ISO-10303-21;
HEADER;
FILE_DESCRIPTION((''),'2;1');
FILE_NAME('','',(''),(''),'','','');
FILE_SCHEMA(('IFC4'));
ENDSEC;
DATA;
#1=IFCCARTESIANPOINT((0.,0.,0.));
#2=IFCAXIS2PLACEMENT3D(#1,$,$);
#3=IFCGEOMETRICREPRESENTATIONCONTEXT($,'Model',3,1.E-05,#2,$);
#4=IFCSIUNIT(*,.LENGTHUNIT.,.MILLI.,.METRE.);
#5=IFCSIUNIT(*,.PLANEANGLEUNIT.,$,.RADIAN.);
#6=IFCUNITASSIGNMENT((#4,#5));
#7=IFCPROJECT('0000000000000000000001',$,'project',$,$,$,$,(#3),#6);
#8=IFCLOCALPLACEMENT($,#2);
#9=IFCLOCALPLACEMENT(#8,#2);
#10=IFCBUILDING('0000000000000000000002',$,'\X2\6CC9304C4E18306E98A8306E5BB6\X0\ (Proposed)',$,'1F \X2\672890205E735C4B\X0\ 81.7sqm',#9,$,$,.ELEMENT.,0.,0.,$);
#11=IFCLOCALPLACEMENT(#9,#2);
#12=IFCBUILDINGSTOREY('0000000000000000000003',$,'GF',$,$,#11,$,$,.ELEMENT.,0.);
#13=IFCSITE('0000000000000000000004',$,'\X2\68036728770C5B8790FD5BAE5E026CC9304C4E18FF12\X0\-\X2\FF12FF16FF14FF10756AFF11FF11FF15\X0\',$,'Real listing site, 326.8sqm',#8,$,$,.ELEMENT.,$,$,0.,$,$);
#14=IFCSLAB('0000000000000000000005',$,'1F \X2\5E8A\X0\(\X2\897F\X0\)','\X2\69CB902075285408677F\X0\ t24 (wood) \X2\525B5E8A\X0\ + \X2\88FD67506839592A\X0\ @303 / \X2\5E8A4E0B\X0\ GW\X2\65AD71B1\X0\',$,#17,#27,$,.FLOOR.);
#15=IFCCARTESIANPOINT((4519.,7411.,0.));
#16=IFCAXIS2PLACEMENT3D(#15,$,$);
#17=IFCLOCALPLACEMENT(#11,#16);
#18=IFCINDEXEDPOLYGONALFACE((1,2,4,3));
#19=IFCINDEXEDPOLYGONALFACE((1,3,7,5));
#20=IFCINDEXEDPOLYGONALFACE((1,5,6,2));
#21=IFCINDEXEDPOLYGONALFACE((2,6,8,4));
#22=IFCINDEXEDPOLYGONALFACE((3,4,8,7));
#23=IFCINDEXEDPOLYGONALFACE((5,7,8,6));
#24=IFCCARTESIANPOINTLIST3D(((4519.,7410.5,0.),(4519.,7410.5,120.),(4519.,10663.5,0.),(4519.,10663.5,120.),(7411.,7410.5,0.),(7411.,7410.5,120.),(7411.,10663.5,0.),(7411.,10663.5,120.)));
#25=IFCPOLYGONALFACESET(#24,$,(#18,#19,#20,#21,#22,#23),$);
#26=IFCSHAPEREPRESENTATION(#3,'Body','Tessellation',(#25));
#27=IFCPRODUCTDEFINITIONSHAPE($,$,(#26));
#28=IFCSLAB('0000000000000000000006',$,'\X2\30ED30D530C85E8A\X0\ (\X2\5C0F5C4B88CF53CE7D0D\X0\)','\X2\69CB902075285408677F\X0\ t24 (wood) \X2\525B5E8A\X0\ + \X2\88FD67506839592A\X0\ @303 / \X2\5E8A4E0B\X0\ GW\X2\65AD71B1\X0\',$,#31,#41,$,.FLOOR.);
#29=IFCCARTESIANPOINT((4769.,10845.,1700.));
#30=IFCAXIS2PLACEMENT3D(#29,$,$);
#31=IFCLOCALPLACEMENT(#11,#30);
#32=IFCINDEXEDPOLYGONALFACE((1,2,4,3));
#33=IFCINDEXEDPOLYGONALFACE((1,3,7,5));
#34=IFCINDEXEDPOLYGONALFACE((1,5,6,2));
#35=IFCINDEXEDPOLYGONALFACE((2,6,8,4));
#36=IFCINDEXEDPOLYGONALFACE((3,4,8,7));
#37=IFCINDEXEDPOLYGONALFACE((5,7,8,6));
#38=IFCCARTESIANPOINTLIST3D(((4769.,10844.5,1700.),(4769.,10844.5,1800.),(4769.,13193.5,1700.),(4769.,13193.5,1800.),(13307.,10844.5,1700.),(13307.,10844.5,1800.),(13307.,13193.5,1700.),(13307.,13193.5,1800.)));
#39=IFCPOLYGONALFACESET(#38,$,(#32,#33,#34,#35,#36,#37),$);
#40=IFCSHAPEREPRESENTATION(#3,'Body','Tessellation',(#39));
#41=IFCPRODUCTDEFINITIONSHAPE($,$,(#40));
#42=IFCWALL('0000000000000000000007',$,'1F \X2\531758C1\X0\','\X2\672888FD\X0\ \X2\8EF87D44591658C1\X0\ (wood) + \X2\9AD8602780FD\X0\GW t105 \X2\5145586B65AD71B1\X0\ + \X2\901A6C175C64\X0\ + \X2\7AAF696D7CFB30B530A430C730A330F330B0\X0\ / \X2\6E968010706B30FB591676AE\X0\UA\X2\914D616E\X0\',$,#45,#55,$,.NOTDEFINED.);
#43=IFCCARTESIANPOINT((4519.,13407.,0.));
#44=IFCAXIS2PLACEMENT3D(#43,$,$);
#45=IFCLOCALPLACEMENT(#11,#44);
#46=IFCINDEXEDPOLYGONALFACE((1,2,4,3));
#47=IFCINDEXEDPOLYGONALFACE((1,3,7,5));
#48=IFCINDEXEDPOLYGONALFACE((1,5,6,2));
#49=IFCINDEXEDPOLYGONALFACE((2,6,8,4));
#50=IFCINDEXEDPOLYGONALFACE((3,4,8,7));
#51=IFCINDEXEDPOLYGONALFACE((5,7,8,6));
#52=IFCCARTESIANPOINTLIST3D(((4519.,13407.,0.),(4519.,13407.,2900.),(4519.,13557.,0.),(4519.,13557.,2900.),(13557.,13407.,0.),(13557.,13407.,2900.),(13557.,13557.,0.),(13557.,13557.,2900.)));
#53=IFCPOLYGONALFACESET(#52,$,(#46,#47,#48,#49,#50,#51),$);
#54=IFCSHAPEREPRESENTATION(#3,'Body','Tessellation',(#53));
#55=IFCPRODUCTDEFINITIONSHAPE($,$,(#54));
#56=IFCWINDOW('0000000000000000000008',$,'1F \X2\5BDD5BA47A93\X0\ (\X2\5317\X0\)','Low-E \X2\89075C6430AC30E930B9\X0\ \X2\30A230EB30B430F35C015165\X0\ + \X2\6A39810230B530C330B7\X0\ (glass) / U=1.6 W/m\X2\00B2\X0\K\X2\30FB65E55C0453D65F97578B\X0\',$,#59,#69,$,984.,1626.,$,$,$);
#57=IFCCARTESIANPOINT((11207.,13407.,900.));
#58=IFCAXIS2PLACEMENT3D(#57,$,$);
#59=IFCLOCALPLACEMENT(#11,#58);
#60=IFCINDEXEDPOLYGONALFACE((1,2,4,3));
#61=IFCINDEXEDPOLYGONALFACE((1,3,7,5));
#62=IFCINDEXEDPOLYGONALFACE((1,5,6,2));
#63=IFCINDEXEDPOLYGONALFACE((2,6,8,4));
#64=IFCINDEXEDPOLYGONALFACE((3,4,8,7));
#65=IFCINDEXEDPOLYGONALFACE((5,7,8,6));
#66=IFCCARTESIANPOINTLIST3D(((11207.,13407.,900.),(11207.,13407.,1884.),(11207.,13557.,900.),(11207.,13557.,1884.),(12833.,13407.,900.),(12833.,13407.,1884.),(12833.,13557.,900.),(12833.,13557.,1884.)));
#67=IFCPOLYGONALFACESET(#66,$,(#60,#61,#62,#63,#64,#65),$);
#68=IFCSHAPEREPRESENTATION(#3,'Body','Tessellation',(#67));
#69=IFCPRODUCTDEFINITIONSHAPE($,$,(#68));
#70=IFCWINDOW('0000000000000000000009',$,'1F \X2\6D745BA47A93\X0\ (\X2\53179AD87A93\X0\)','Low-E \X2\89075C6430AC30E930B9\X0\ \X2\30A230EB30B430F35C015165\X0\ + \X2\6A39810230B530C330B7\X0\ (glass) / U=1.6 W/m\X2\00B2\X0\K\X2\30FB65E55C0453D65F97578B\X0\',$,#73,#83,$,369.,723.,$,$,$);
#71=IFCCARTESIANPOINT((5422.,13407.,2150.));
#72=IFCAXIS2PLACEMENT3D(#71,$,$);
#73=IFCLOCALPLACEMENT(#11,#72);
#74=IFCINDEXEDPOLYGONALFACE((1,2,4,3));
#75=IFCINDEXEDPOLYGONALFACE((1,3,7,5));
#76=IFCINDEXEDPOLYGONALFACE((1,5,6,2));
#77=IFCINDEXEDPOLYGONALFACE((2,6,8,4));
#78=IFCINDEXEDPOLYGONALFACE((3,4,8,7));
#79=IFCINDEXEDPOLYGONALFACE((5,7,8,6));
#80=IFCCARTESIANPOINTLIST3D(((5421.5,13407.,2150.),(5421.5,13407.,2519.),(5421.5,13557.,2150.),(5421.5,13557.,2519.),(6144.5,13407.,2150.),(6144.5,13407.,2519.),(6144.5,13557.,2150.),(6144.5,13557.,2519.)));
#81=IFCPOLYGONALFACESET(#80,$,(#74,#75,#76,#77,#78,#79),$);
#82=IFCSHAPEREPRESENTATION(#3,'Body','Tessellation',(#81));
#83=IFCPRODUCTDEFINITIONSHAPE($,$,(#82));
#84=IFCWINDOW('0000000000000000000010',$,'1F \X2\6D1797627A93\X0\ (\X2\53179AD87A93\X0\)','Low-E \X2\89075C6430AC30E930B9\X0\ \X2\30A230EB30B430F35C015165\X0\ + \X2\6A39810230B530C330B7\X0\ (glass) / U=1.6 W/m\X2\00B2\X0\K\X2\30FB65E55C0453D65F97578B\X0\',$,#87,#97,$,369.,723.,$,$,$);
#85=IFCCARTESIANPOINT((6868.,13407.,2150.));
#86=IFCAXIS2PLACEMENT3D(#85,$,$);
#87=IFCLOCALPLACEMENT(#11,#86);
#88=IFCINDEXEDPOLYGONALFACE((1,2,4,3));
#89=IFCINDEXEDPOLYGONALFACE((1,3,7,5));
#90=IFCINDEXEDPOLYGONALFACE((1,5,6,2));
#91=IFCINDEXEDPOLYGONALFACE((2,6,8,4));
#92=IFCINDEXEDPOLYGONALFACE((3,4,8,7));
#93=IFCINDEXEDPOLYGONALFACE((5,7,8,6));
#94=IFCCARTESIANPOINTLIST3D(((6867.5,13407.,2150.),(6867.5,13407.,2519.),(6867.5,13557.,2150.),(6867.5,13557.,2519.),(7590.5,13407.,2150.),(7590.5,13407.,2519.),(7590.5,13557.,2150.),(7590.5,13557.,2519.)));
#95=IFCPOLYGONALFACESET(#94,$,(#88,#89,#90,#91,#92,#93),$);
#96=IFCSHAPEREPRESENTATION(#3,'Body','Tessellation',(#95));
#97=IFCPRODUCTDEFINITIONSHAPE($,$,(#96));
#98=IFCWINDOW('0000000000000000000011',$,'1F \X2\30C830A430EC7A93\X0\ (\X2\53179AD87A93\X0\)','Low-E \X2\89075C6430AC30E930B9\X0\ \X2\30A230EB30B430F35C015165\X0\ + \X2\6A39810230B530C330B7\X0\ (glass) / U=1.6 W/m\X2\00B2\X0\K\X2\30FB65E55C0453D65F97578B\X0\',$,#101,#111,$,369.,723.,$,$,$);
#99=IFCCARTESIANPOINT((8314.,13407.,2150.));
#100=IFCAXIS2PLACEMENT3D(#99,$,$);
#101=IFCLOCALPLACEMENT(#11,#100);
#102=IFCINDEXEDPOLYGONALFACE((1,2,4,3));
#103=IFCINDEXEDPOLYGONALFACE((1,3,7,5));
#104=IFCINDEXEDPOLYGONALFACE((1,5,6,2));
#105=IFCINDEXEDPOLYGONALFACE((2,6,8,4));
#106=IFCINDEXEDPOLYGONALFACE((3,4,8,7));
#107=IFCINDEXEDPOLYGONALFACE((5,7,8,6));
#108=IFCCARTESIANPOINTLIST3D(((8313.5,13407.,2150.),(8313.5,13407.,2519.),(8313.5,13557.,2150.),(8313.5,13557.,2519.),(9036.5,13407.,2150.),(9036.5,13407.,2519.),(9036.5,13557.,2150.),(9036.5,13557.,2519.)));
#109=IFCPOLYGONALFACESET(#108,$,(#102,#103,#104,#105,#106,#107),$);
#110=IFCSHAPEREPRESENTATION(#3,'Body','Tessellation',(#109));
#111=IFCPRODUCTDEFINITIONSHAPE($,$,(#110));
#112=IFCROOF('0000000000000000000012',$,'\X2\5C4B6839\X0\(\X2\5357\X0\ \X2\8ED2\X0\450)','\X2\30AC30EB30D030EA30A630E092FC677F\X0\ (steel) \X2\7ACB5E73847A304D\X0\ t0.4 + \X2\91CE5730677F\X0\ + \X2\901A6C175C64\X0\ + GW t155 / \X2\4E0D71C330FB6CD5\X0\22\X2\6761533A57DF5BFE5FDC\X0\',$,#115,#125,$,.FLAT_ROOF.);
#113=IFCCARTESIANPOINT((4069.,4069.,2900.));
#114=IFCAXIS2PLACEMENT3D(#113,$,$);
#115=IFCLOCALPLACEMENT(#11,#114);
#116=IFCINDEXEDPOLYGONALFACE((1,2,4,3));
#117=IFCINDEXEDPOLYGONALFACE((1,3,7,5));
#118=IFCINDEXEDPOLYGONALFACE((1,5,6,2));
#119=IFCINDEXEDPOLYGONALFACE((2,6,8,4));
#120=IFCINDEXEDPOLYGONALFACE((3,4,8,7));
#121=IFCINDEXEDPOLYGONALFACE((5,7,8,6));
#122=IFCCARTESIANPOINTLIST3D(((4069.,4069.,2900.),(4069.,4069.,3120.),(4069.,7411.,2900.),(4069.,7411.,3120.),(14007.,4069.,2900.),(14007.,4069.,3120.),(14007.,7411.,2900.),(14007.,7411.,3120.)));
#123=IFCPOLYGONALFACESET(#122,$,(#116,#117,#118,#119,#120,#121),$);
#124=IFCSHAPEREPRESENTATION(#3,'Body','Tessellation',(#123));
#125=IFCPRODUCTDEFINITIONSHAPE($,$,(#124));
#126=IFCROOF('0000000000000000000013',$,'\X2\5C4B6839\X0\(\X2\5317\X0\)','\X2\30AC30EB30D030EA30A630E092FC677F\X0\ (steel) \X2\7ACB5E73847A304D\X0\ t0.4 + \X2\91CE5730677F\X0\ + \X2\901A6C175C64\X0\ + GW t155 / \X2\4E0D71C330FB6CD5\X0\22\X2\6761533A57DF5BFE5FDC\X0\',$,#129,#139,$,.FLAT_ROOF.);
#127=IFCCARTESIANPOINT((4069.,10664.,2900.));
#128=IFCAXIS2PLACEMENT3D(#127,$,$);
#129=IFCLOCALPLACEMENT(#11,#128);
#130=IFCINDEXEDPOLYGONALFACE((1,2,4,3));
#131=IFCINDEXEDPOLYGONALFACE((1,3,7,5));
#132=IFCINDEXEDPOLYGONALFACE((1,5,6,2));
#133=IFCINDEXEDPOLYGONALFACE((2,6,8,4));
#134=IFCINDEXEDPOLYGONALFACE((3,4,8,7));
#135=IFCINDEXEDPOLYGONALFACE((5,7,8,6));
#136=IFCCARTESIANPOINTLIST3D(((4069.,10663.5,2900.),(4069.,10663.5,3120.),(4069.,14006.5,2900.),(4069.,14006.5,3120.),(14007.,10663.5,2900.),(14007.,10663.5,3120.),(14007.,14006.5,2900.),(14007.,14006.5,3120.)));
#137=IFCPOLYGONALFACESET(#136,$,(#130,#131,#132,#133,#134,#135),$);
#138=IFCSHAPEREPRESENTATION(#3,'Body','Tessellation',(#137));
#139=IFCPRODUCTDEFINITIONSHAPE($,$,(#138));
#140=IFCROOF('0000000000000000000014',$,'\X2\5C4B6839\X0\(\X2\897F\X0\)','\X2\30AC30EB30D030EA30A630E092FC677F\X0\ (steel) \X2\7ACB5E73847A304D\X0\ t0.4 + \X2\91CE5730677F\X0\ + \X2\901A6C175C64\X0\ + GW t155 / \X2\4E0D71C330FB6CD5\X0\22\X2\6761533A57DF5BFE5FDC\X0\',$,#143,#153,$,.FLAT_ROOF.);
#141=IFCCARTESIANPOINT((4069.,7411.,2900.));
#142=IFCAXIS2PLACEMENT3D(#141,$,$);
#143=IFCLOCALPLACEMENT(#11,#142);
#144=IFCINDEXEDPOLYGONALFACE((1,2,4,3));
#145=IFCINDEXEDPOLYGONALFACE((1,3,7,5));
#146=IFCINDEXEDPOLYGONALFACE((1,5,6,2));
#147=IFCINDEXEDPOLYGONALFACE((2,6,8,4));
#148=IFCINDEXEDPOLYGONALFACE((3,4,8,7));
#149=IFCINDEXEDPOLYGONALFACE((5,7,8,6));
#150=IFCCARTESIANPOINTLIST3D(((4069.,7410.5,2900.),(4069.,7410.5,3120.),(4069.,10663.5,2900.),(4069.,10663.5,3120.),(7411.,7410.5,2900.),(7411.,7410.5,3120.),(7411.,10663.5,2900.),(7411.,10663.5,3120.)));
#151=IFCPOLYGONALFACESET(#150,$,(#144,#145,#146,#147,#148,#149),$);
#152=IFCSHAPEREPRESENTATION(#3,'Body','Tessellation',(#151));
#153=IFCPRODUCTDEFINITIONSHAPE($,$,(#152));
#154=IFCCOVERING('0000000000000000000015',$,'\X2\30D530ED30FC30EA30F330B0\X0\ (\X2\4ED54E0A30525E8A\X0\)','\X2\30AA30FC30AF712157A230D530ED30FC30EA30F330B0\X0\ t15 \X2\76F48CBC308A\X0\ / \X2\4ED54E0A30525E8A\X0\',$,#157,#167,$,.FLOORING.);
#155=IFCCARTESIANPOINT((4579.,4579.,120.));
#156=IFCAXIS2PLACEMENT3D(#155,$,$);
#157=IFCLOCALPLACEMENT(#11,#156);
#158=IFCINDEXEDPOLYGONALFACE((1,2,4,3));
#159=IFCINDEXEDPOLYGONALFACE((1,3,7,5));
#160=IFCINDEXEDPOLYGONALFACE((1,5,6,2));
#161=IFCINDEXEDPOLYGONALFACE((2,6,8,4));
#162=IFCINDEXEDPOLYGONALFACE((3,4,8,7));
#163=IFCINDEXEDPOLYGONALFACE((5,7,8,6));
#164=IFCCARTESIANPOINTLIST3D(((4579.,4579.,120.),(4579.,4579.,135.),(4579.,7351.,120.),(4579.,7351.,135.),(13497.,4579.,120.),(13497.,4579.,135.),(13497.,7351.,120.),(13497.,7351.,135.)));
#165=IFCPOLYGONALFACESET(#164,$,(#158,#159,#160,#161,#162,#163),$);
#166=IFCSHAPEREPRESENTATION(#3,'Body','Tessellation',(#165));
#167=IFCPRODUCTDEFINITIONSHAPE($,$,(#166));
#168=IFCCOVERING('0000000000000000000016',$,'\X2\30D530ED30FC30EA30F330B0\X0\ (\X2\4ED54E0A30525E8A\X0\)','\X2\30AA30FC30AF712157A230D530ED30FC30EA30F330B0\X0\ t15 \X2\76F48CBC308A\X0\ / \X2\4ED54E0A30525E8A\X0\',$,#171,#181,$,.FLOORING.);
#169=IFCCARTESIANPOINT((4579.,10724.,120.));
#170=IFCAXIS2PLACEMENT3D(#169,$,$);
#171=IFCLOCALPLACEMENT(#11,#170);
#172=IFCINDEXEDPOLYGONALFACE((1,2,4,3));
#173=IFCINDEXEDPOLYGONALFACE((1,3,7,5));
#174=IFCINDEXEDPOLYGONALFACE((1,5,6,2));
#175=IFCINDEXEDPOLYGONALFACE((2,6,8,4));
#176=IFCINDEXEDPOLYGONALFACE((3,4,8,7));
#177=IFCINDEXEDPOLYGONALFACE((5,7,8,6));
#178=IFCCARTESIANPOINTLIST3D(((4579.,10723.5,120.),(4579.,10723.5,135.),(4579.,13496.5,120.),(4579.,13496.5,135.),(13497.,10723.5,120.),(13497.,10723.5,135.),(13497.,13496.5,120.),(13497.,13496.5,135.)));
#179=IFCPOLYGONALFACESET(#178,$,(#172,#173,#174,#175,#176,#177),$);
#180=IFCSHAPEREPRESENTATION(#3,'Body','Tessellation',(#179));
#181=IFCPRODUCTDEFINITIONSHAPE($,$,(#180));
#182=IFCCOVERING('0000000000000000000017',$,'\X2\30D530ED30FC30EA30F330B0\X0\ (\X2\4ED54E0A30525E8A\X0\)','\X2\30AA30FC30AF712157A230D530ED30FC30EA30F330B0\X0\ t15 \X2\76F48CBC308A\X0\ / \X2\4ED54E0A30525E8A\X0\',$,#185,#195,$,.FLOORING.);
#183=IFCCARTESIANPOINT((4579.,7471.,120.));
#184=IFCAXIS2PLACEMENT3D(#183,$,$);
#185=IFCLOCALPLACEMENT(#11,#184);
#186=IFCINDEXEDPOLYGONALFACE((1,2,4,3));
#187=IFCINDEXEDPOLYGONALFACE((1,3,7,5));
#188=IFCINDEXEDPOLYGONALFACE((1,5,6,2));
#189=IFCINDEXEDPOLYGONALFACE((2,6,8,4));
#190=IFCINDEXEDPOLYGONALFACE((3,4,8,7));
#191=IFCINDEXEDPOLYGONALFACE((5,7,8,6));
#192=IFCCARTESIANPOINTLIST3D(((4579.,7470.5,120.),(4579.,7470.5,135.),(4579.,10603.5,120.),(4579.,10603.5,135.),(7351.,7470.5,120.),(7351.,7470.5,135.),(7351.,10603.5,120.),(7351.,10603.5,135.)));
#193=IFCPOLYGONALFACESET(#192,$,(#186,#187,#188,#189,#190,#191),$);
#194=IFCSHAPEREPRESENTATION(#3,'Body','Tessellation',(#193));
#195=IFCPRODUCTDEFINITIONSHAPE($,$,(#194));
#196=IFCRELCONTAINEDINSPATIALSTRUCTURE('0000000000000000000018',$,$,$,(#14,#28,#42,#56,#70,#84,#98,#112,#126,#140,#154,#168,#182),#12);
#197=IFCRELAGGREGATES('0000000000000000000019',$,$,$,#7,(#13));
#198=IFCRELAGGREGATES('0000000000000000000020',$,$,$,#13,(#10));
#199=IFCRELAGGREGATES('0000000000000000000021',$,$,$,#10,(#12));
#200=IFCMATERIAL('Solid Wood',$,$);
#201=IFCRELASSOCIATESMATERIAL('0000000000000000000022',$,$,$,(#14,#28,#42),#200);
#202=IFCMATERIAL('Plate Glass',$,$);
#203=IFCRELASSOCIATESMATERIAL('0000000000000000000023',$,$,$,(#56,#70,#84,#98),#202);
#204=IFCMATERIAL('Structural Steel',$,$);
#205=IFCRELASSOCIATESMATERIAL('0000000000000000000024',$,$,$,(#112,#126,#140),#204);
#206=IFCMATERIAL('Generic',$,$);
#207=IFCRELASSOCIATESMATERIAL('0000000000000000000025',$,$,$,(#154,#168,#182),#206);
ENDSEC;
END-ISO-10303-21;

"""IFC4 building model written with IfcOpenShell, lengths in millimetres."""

from ifc_helpers import new_model, si_unit, frame, frame_2d, origin, place, context, project, spatial, rectangle, extrude, material, element, fill, save


model = new_model("IFC4")

# Units and contexts
model_context = context("Model", 3, precision=1e-05, world=origin())
ifc_project = project(units=[si_unit("LENGTHUNIT", "METRE", prefix="MILLI"), si_unit("PLANEANGLEUNIT", "RADIAN")], contexts=[model_context])

# Site, building, storey
site_placement = place(None, origin())
site = spatial("IfcSite", under=ifc_project, at=site_placement, Name="栃木県宇都宮市泉が丘２-２６４０番１１５", ObjectType="Real listing site, 326.8sqm", CompositionType="ELEMENT", RefElevation=0.0)
building_placement = place(site_placement, origin())
building = spatial("IfcBuilding", under=site, at=building_placement, Name="泉が丘の風の家 (Proposed)", ObjectType="1F 木造平屋 81.7sqm", CompositionType="ELEMENT", ElevationOfRefHeight=0.0, ElevationOfTerrain=0.0)
storey_placement = place(building_placement, origin())
storey = spatial("IfcBuildingStorey", under=building, at=storey_placement, Name="GF", CompositionType="ELEMENT", Elevation=0.0)

# Slabs
ifc_material_1 = material(Name="Solid Wood")
slab_1_placement = place(storey_placement, frame((4519.0, 7411.0, 0.0)))
element("IfcSlab", 1, at=slab_1_placement, inside=storey, material=ifc_material_1, Name="1F 床(西)", Description="構造用合板 t24 (wood) 剛床 + 製材根太 @303 / 床下 GW断熱", PredefinedType="FLOOR", context=model_context, shape_type="SweptSolid", body=[
    extrude(rectangle(XDim=2892.0, YDim=3253.0, at=frame_2d((1446.0, 1626.0))), frame((4519.0, 7411.0, 0.0)), (0.0, 0.0, 1.0), 120.0),
])
slab_2_placement = place(storey_placement, frame((4769.0, 10845.0, 1700.0)))
element("IfcSlab", 2, at=slab_2_placement, inside=storey, material=ifc_material_1, Name="ロフト床 (小屋裏収納)", Description="構造用合板 t24 (wood) 剛床 + 製材根太 @303 / 床下 GW断熱", PredefinedType="FLOOR", context=model_context, shape_type="SweptSolid", body=[
    extrude(rectangle(XDim=8538.0, YDim=2349.0, at=frame_2d((4269.0, 1174.0))), frame((4769.0, 10845.0, 1700.0)), (0.0, 0.0, 1.0), 100.0),
])

# Shared definitions
ifc_material_2 = material(Name="Plate Glass")

# Wall, openings, windows
wall_1_placement = place(storey_placement, frame((4519.0, 13407.0, 0.0)))
wall_1 = element("IfcWall", 3, at=wall_1_placement, inside=storey, material=ifc_material_1, Name="1F 北壁", Description="木製 軸組外壁 (wood) + 高性能GW t105 充填断熱 + 通気層 + 窯業系サイディング / 準耐火・外皮UA配慮", PredefinedType="NOTDEFINED", context=model_context, shape_type="SweptSolid", body=[
    extrude(rectangle(XDim=9038.0, YDim=150.0, at=frame_2d((4519.0, 75.0))), frame((4519.0, 13407.0, 0.0)), (0.0, 0.0, 1.0), 2900.0),
])
opening_1_placement = place(storey_placement, frame((11207.0, 13407.0, 900.0)))
opening_1 = element("IfcOpeningElement", 4, at=opening_1_placement, cuts=wall_1, PredefinedType="NOTDEFINED", context=model_context, shape_type="SweptSolid", body=[
    extrude(rectangle(XDim=1626.0, YDim=150.0, at=frame_2d((813.0, 75.0))), frame((11207.0, 13407.0, 900.0)), (0.0, 0.0, 1.0), 984.0),
])
opening_2_placement = place(storey_placement, frame((5422.0, 13407.0, 2150.0)))
opening_2 = element("IfcOpeningElement", 5, at=opening_2_placement, cuts=wall_1, PredefinedType="NOTDEFINED", context=model_context, shape_type="SweptSolid", body=[
    extrude(rectangle(XDim=723.0, YDim=150.0, at=frame_2d((361.0, 75.0))), frame((5422.0, 13407.0, 2150.0)), (0.0, 0.0, 1.0), 369.0),
])
opening_3_placement = place(storey_placement, frame((6868.0, 13407.0, 2150.0)))
opening_3 = element("IfcOpeningElement", 6, at=opening_3_placement, cuts=wall_1, PredefinedType="NOTDEFINED", context=model_context, shape_type="SweptSolid", body=[
    extrude(rectangle(XDim=723.0, YDim=150.0, at=frame_2d((361.0, 75.0))), frame((6868.0, 13407.0, 2150.0)), (0.0, 0.0, 1.0), 369.0),
])
opening_4_placement = place(storey_placement, frame((8314.0, 13407.0, 2150.0)))
opening_4 = element("IfcOpeningElement", 7, at=opening_4_placement, cuts=wall_1, PredefinedType="NOTDEFINED", context=model_context, shape_type="SweptSolid", body=[
    extrude(rectangle(XDim=723.0, YDim=150.0, at=frame_2d((361.0, 75.0))), frame((8314.0, 13407.0, 2150.0)), (0.0, 0.0, 1.0), 369.0),
])
window_1_placement = place(storey_placement, frame((11207.0, 13407.0, 900.0)))
window_1 = element("IfcWindow", 8, at=window_1_placement, inside=storey, material=ifc_material_2, Name="1F 寝室窓 (北)", Description="Low-E 複層ガラス アルゴン封入 + 樹脂サッシ (glass) / U=1.6 W/m²K・日射取得型", OverallHeight=984.0, OverallWidth=1626.0, context=model_context, shape_type="SweptSolid", body=[
    extrude(rectangle(XDim=1626.0, YDim=150.0, at=frame_2d((813.0, 75.0))), frame((11207.0, 13407.0, 900.0)), (0.0, 0.0, 1.0), 984.0),
])
fill(opening_1, window_1)
window_2_placement = place(storey_placement, frame((5422.0, 13407.0, 2150.0)))
window_2 = element("IfcWindow", 9, at=window_2_placement, inside=storey, material=ifc_material_2, Name="1F 浴室窓 (北高窓)", Description="Low-E 複層ガラス アルゴン封入 + 樹脂サッシ (glass) / U=1.6 W/m²K・日射取得型", OverallHeight=369.0, OverallWidth=723.0, context=model_context, shape_type="SweptSolid", body=[
    extrude(rectangle(XDim=723.0, YDim=150.0, at=frame_2d((361.0, 75.0))), frame((5422.0, 13407.0, 2150.0)), (0.0, 0.0, 1.0), 369.0),
])
fill(opening_2, window_2)
window_3_placement = place(storey_placement, frame((6868.0, 13407.0, 2150.0)))
window_3 = element("IfcWindow", 10, at=window_3_placement, inside=storey, material=ifc_material_2, Name="1F 洗面窓 (北高窓)", Description="Low-E 複層ガラス アルゴン封入 + 樹脂サッシ (glass) / U=1.6 W/m²K・日射取得型", OverallHeight=369.0, OverallWidth=723.0, context=model_context, shape_type="SweptSolid", body=[
    extrude(rectangle(XDim=723.0, YDim=150.0, at=frame_2d((361.0, 75.0))), frame((6868.0, 13407.0, 2150.0)), (0.0, 0.0, 1.0), 369.0),
])
fill(opening_3, window_3)
window_4_placement = place(storey_placement, frame((8314.0, 13407.0, 2150.0)))
window_4 = element("IfcWindow", 11, at=window_4_placement, inside=storey, material=ifc_material_2, Name="1F トイレ窓 (北高窓)", Description="Low-E 複層ガラス アルゴン封入 + 樹脂サッシ (glass) / U=1.6 W/m²K・日射取得型", OverallHeight=369.0, OverallWidth=723.0, context=model_context, shape_type="SweptSolid", body=[
    extrude(rectangle(XDim=723.0, YDim=150.0, at=frame_2d((361.0, 75.0))), frame((8314.0, 13407.0, 2150.0)), (0.0, 0.0, 1.0), 369.0),
])
fill(opening_4, window_4)

# Roofs
ifc_material_3 = material(Name="Structural Steel")
roof_1_placement = place(storey_placement, frame((4069.0, 4069.0, 2900.0)))
element("IfcRoof", 12, at=roof_1_placement, inside=storey, material=ifc_material_3, Name="屋根(南 軒450)", Description="ガルバリウム鋼板 (steel) 立平葺き t0.4 + 野地板 + 通気層 + GW t155 / 不燃・法22条区域対応", PredefinedType="FLAT_ROOF", context=model_context, shape_type="SweptSolid", body=[
    extrude(rectangle(XDim=9938.0, YDim=3342.0, at=frame_2d((4969.0, 1671.0))), frame((4069.0, 4069.0, 2900.0)), (0.0, 0.0, 1.0), 220.0),
])
roof_2_placement = place(storey_placement, frame((4069.0, 10664.0, 2900.0)))
element("IfcRoof", 13, at=roof_2_placement, inside=storey, material=ifc_material_3, Name="屋根(北)", Description="ガルバリウム鋼板 (steel) 立平葺き t0.4 + 野地板 + 通気層 + GW t155 / 不燃・法22条区域対応", PredefinedType="FLAT_ROOF", context=model_context, shape_type="SweptSolid", body=[
    extrude(rectangle(XDim=9938.0, YDim=3343.0, at=frame_2d((4969.0, 1671.0))), frame((4069.0, 10664.0, 2900.0)), (0.0, 0.0, 1.0), 220.0),
])
roof_3_placement = place(storey_placement, frame((4069.0, 7411.0, 2900.0)))
element("IfcRoof", 14, at=roof_3_placement, inside=storey, material=ifc_material_3, Name="屋根(西)", Description="ガルバリウム鋼板 (steel) 立平葺き t0.4 + 野地板 + 通気層 + GW t155 / 不燃・法22条区域対応", PredefinedType="FLAT_ROOF", context=model_context, shape_type="SweptSolid", body=[
    extrude(rectangle(XDim=3342.0, YDim=3253.0, at=frame_2d((1671.0, 1626.0))), frame((4069.0, 7411.0, 2900.0)), (0.0, 0.0, 1.0), 220.0),
])

# Coverings
ifc_material_4 = material(Name="Generic")
covering_1_placement = place(storey_placement, frame((4579.0, 4579.0, 120.0)))
element("IfcCovering", 15, at=covering_1_placement, inside=storey, material=ifc_material_4, Name="フローリング (仕上げ床)", Description="オーク無垢フローリング t15 直貼り / 仕上げ床", PredefinedType="FLOORING", context=model_context, shape_type="SweptSolid", body=[
    extrude(rectangle(XDim=8918.0, YDim=2772.0, at=frame_2d((4459.0, 1386.0))), frame((4579.0, 4579.0, 120.0)), (0.0, 0.0, 1.0), 15.0),
])
covering_2_placement = place(storey_placement, frame((4579.0, 10724.0, 120.0)))
element("IfcCovering", 16, at=covering_2_placement, inside=storey, material=ifc_material_4, Name="フローリング (仕上げ床)", Description="オーク無垢フローリング t15 直貼り / 仕上げ床", PredefinedType="FLOORING", context=model_context, shape_type="SweptSolid", body=[
    extrude(rectangle(XDim=8918.0, YDim=2773.0, at=frame_2d((4459.0, 1386.0))), frame((4579.0, 10724.0, 120.0)), (0.0, 0.0, 1.0), 15.0),
])
covering_3_placement = place(storey_placement, frame((4579.0, 7471.0, 120.0)))
element("IfcCovering", 17, at=covering_3_placement, inside=storey, material=ifc_material_4, Name="フローリング (仕上げ床)", Description="オーク無垢フローリング t15 直貼り / 仕上げ床", PredefinedType="FLOORING", context=model_context, shape_type="SweptSolid", body=[
    extrude(rectangle(XDim=2772.0, YDim=3133.0, at=frame_2d((1386.0, 1566.0))), frame((4579.0, 7471.0, 120.0)), (0.0, 0.0, 1.0), 15.0),
])

save(model, "model.ifc")
